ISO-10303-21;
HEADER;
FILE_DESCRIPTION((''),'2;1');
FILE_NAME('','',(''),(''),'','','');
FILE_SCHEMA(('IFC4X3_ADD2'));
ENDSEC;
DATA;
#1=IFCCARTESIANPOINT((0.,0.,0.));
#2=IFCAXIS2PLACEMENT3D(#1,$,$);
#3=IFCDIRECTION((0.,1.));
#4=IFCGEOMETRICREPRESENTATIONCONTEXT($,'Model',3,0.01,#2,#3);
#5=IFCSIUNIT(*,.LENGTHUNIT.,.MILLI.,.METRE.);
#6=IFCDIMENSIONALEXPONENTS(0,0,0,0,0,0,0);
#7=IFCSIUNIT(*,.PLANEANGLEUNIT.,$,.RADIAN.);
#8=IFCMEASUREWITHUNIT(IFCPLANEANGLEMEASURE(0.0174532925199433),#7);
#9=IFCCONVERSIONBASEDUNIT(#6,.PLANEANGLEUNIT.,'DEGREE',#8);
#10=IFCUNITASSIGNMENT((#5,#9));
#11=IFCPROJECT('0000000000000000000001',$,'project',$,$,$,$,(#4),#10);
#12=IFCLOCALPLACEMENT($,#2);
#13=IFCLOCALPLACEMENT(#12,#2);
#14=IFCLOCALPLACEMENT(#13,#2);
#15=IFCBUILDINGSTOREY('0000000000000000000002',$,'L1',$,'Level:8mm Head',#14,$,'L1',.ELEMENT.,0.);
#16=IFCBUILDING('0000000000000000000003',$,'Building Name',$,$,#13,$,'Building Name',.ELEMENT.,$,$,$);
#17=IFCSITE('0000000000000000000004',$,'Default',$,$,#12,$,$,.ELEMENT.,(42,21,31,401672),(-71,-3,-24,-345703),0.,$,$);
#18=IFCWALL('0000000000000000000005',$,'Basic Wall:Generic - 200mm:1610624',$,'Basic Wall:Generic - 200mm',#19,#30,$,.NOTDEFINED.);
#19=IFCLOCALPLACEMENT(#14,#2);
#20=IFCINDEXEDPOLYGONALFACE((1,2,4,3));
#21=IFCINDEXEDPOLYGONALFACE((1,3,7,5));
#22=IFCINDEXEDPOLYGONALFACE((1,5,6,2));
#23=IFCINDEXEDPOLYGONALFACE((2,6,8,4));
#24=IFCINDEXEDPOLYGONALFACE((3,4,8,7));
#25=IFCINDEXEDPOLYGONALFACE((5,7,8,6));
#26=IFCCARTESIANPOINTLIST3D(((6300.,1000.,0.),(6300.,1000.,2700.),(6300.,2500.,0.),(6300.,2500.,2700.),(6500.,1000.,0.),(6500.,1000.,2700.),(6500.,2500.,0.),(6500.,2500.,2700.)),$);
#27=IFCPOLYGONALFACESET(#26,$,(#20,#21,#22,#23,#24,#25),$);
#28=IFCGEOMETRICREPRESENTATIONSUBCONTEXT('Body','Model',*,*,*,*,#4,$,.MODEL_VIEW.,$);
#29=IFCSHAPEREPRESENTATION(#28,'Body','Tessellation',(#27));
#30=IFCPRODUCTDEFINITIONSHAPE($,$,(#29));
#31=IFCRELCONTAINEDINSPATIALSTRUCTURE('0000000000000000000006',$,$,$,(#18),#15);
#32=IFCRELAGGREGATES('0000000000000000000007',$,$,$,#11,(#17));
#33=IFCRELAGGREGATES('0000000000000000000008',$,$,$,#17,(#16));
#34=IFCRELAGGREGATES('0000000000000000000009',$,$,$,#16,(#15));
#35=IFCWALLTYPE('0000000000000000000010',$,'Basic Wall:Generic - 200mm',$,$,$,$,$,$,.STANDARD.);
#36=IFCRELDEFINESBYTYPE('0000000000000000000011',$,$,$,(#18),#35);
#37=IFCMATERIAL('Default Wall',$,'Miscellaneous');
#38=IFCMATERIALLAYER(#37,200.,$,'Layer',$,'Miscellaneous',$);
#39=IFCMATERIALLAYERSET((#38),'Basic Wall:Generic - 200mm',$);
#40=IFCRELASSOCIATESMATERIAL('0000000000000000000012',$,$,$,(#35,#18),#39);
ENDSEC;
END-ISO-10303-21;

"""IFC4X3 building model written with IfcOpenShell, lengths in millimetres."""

from ifc_helpers import new_model, entity, si_unit, converted_unit, direction, frame, frame_2d, origin, place, context, subcontext, project, spatial, polyline, rectangle, extrude, clip, bounded_halfspace, material, layer, layer_set, type_object, element, save


model = new_model("IFC4X3")

# Units and contexts
model_context = context("Model", 3, precision=0.01, world=origin(), true_north=direction((0.0, 1.0)))
body_context = subcontext(model_context, "Body", "Model", "MODEL_VIEW")
ifc_project = project(units=[si_unit("LENGTHUNIT", "METRE", prefix="MILLI"), converted_unit("PLANEANGLEUNIT", "DEGREE", entity("IfcPlaneAngleMeasure", 0.0174532925199433), si_unit("PLANEANGLEUNIT", "RADIAN"), dimensions=[0, 0, 0, 0, 0, 0, 0])], contexts=[model_context])

# Site, building, storey
site_placement = place(None, origin())
site = spatial("IfcSite", under=ifc_project, at=site_placement, Name="Default", CompositionType="ELEMENT", RefLatitude=(42, 21, 31, 401672), RefLongitude=(-71, -3, -24, -345703), RefElevation=0.0)
building_placement = place(site_placement, origin())
building = spatial("IfcBuilding", under=site, at=building_placement, Name="Building Name", LongName="Building Name", CompositionType="ELEMENT")
storey_placement = place(building_placement, origin())
storey = spatial("IfcBuildingStorey", under=building, at=storey_placement, Name="L1", ObjectType="Level:8mm Head", LongName="L1", CompositionType="ELEMENT", Elevation=0.0)

# Wall
ifc_material = material(Name="Default Wall", Category="Miscellaneous")
ifc_layer = layer(ifc_material, 200.0, Name="Layer", Category="Miscellaneous")
ifc_layer_set = layer_set([ifc_layer], Name="Basic Wall:Generic - 200mm")
wall_type = type_object("IfcWallType", Name="Basic Wall:Generic - 200mm", PredefinedType="STANDARD", material=ifc_layer_set)
wall_1_placement = place(storey_placement, frame((6400.0, 2500.0, 0.0), z_axis=(0.0, 0.0, 1.0), x_axis=(0.0, -1.0, 0.0)))
element("IfcWall", 1, at=wall_1_placement, inside=storey, type_object=wall_type, material=ifc_layer_set, Name="Basic Wall:Generic - 200mm:1610624", ObjectType="Basic Wall:Generic - 200mm", PredefinedType="NOTDEFINED", context=body_context, shape_type="Clipping", body=[
    clip(extrude(rectangle(XDim=1500.0, YDim=200.0, at=frame_2d((750.0, 0.0), x_axis=(-1.0, 0.0))), origin(), (0.0, 0.0, 1.0), 2700.0), bounded_halfspace(frame((0.0, -100.0, 2700.0), z_axis=(0.0, 0.0, -1.0), x_axis=(0.0, -1.0, 0.0)), True, frame((0.0, -100.0, 2700.0)), polyline([(0.0, 0.0), (1500.0, 0.0), (1500.0, 200.0), (0.0, 200.0), (0.0, 0.0)]))),
])

save(model, "model.ifc")
